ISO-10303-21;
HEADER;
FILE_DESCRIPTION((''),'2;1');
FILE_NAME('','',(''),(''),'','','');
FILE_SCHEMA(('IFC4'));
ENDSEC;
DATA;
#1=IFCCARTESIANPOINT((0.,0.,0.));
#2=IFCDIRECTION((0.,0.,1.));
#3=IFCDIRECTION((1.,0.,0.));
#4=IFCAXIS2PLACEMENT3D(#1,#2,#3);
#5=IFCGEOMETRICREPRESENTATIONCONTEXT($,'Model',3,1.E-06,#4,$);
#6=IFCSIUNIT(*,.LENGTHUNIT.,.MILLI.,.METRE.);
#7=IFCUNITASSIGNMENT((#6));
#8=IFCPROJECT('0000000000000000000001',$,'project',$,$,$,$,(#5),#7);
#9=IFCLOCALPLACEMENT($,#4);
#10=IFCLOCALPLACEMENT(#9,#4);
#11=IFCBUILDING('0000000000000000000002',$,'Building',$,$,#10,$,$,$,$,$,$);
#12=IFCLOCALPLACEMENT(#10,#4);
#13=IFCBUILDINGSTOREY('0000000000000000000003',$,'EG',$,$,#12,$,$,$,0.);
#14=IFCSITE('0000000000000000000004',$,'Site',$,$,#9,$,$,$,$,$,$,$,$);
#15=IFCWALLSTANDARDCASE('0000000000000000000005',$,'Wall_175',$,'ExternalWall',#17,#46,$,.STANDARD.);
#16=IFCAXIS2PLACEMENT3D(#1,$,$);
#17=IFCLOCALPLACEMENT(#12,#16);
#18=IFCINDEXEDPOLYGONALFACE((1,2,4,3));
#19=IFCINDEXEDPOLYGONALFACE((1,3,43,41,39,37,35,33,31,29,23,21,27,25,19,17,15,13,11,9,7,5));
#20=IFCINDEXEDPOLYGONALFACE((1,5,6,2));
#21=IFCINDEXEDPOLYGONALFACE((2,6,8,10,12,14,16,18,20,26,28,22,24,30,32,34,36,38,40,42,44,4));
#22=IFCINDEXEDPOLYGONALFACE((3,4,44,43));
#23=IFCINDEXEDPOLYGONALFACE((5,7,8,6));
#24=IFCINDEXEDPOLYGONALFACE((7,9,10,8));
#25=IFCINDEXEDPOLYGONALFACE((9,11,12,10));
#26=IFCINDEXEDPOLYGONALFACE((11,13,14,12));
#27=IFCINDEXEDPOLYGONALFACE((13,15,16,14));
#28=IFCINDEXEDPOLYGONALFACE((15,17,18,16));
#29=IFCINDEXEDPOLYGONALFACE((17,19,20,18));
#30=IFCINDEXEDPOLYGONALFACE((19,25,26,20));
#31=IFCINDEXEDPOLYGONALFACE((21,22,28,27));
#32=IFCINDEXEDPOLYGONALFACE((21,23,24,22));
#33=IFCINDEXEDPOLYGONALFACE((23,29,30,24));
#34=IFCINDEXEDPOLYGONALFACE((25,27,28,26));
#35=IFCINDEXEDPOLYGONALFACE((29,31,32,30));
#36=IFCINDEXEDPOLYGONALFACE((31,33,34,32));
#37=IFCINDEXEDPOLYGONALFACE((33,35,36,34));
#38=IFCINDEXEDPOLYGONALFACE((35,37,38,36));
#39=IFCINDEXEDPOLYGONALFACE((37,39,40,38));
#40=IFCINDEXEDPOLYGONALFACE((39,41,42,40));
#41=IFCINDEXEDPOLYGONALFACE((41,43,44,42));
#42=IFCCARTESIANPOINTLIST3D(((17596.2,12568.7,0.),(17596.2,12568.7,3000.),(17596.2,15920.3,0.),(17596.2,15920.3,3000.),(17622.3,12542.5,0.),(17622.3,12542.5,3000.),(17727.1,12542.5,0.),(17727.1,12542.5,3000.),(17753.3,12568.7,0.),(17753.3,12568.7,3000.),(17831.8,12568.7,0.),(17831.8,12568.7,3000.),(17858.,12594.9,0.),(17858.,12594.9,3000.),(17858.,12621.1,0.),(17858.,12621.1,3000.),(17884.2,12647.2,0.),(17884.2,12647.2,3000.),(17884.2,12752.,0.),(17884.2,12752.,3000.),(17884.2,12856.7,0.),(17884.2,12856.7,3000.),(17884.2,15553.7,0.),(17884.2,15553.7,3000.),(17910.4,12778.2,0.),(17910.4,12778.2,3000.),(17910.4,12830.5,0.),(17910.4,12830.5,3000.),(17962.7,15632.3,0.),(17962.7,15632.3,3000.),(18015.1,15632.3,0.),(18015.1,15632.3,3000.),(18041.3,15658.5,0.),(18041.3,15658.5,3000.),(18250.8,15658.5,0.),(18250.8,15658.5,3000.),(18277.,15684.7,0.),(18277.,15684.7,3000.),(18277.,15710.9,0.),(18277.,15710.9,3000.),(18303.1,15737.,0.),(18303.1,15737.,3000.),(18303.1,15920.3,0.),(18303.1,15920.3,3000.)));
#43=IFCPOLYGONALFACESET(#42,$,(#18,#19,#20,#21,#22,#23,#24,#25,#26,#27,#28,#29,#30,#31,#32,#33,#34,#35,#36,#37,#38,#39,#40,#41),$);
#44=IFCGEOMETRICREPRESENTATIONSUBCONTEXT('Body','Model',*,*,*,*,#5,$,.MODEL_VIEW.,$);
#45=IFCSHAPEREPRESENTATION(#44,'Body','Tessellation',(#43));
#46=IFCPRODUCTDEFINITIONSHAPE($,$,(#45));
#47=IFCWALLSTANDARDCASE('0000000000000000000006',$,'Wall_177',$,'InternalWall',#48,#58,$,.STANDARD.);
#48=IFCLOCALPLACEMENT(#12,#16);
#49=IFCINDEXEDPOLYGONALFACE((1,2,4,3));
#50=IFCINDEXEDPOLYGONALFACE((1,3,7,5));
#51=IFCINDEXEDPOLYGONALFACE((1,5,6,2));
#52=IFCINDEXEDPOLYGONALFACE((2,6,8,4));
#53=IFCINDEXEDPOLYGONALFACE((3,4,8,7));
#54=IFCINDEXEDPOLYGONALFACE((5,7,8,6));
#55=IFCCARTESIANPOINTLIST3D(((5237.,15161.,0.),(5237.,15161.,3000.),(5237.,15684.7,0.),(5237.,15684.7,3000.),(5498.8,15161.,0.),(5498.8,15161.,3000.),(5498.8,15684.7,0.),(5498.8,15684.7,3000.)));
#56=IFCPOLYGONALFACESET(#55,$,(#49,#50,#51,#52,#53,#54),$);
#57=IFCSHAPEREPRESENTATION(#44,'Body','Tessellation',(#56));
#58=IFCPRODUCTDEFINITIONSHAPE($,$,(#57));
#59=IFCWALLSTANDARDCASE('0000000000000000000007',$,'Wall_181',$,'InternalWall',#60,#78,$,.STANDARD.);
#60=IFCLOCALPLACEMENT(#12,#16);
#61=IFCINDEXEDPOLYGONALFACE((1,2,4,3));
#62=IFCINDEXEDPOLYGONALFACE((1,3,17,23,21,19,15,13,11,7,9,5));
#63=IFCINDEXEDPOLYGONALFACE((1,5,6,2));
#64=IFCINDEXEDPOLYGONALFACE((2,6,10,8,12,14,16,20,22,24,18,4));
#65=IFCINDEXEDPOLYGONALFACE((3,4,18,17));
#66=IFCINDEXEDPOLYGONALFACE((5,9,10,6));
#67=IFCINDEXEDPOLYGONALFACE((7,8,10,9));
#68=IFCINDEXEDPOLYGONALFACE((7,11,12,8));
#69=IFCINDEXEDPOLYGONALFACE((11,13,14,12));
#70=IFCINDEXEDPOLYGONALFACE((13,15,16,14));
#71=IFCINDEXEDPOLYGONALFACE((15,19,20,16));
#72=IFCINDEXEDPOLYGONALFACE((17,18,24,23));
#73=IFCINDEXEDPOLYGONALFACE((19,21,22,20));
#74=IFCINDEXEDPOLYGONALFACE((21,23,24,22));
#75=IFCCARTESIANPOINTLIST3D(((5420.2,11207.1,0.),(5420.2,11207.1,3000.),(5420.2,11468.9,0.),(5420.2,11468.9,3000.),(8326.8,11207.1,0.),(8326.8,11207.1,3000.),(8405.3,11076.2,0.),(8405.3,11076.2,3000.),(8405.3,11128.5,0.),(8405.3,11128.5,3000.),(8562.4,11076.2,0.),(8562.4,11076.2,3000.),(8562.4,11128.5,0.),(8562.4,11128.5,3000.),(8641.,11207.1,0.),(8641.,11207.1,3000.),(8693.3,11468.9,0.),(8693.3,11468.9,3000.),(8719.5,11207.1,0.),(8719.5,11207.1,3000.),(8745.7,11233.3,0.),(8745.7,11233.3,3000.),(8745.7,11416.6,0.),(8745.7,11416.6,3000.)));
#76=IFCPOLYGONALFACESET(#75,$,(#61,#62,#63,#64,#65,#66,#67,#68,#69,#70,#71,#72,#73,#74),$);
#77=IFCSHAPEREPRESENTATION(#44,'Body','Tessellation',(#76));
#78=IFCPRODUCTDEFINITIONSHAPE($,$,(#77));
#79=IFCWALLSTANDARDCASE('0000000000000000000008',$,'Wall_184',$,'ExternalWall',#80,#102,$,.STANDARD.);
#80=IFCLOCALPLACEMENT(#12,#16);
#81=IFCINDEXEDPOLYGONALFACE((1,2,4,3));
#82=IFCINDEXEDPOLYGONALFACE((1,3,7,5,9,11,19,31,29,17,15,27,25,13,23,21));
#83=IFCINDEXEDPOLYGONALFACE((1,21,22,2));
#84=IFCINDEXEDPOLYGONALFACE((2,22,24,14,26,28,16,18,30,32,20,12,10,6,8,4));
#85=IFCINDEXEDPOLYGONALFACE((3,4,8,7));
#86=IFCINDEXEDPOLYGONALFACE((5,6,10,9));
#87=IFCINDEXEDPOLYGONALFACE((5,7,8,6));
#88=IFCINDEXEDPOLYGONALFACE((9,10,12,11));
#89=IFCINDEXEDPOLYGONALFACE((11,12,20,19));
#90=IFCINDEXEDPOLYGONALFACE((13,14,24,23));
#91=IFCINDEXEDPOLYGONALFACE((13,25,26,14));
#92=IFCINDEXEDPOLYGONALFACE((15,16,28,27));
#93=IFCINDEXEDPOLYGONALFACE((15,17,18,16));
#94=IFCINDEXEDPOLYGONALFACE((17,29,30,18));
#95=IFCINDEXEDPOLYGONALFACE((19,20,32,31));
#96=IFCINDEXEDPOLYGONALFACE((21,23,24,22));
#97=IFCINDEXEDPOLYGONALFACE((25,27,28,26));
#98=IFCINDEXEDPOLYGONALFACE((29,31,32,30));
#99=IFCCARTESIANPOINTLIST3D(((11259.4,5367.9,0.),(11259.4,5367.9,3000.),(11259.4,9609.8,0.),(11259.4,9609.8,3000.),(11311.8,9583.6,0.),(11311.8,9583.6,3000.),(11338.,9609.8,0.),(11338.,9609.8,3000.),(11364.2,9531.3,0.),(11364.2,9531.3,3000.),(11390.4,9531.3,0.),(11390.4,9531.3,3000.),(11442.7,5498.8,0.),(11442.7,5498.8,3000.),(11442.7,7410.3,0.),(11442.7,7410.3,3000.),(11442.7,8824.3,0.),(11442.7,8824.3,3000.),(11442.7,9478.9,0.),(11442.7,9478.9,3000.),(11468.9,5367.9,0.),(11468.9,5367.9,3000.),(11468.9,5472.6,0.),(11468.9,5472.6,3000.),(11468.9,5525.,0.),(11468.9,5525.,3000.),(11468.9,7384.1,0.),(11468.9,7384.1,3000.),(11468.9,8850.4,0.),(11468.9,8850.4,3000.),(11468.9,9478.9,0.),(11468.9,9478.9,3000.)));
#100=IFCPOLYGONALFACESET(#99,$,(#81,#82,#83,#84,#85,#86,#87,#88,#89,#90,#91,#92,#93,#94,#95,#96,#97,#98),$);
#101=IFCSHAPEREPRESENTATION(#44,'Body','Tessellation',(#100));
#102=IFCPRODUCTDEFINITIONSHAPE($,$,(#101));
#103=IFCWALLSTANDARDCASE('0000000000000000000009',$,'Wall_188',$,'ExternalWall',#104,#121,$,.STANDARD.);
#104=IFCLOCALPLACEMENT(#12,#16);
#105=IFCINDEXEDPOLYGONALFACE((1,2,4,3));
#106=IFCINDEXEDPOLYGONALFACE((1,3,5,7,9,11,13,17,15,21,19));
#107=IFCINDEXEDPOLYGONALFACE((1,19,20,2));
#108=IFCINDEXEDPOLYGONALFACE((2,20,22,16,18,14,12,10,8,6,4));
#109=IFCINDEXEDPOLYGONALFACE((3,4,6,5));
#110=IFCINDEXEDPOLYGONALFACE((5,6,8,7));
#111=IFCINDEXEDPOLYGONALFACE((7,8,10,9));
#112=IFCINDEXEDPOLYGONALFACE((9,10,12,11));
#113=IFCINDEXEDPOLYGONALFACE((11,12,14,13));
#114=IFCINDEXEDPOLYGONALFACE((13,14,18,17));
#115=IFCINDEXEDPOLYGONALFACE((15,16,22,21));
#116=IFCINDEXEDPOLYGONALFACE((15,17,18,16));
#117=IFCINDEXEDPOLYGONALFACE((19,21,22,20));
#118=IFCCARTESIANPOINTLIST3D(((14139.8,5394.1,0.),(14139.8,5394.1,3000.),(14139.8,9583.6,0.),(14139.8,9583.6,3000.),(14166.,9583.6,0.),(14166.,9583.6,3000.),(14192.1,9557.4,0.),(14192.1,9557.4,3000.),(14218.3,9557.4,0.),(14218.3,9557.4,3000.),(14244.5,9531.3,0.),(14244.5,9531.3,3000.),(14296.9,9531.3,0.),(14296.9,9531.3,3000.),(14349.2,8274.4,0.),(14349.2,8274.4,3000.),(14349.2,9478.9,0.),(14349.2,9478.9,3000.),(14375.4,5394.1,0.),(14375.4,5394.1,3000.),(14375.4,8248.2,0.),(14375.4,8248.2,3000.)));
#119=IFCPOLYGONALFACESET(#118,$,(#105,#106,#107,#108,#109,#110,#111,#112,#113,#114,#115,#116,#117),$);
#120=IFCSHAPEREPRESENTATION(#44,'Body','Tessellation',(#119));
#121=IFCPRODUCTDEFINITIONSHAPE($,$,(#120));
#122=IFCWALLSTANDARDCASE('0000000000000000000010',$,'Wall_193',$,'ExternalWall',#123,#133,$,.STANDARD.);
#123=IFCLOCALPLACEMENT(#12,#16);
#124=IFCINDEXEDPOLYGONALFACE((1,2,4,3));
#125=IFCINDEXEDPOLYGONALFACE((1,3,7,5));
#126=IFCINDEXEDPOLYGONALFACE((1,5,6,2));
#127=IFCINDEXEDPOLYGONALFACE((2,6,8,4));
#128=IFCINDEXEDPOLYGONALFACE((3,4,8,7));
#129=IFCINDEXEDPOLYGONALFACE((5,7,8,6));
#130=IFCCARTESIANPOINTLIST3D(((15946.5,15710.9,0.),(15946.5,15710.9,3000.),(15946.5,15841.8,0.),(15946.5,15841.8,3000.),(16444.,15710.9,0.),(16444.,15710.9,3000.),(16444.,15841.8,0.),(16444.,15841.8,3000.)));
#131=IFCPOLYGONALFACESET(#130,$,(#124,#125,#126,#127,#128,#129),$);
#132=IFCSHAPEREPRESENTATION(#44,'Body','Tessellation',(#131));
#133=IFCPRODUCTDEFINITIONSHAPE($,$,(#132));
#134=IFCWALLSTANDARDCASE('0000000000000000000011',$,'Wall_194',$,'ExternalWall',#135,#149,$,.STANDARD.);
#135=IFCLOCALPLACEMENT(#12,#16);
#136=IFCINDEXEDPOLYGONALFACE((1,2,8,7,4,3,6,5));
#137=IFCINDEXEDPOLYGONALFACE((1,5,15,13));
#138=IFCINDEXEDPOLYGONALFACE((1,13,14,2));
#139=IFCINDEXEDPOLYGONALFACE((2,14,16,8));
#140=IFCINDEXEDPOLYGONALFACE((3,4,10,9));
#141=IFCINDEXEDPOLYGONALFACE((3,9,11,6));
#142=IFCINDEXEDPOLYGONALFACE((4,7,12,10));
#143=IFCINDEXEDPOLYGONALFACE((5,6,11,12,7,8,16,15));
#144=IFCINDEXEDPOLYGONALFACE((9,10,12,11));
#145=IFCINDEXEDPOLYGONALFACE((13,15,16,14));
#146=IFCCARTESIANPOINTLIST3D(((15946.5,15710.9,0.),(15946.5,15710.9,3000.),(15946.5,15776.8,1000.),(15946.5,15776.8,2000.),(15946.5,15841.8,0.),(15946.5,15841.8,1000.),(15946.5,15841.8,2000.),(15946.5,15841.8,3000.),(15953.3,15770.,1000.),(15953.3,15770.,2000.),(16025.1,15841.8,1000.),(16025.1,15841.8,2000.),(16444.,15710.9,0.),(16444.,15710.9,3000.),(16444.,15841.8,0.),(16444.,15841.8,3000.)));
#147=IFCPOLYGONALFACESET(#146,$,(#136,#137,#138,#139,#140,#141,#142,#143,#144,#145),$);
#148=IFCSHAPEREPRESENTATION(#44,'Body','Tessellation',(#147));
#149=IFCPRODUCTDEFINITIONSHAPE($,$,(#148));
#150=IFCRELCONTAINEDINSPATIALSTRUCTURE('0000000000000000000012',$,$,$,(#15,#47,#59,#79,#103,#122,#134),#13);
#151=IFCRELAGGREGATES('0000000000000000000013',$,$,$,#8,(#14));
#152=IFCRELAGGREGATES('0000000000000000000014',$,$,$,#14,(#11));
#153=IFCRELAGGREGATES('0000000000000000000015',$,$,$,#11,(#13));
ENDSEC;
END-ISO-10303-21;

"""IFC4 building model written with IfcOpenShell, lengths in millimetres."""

from ifc_helpers import new_model, si_unit, frame, origin_with_axes, place, context, subcontext, project, spatial, polyline, rectangle, outline, extrude, element, save


model = new_model("IFC4")

# Units and contexts
model_context = context("Model", 3, precision=1e-06, world=origin_with_axes())
body_context = subcontext(model_context, "Body", "Model", "MODEL_VIEW")
ifc_project = project(units=[si_unit("LENGTHUNIT", "METRE", prefix="MILLI")], contexts=[model_context])

# Site, building, storey
site_placement = place(None, origin_with_axes())
site = spatial("IfcSite", under=ifc_project, at=site_placement, Name="Site")
building_placement = place(site_placement, origin_with_axes())
building = spatial("IfcBuilding", under=site, at=building_placement, Name="Building")
storey_placement = place(building_placement, origin_with_axes())
storey = spatial("IfcBuildingStorey", under=building, at=storey_placement, Name="EG", Elevation=0.0)

# Walls
for number, where, z_axis, x_axis, name in (
    (1, (0.0, 0.0, 0.0), (0.0, 0.0, 1.0), (1.0, 0.0, 0.0), "Wall_175"),
):
    element("IfcWallStandardCase", number, at=place(storey_placement, frame(where, z_axis=z_axis, x_axis=x_axis)), inside=storey, Name=name, ObjectType="ExternalWall", PredefinedType="STANDARD", context=body_context, shape_type="SweptSolid", body=[
        extrude(outline(polyline([(17622.3, 12542.5, 0.0), (17596.2, 12568.7, 0.0), (17596.2, 15920.3, 0.0), (18303.1, 15920.3, 0.0), (18303.1, 15737.0, 0.0), (18277.0, 15710.9, 0.0), (18277.0, 15684.7, 0.0), (18250.8, 15658.5, 0.0), (18041.3, 15658.5, 0.0), (18015.1, 15632.3, 0.0), (17962.7, 15632.3, 0.0), (17884.2, 15553.7, 0.0), (17884.2, 12856.7, 0.0), (17910.4, 12830.5, 0.0), (17910.4, 12778.2, 0.0), (17884.2, 12752.0, 0.0), (17884.2, 12647.2, 0.0), (17858.0, 12621.1, 0.0), (17858.0, 12594.9, 0.0), (17831.8, 12568.7, 0.0), (17753.3, 12568.7, 0.0), (17727.1, 12542.5, 0.0), (17622.3, 12542.5, 0.0)])), origin_with_axes(), (0.0, 0.0, 1.0), 3000.0),
    ])
for number, where, z_axis, x_axis, name in (
    (2, (0.0, 0.0, 0.0), (0.0, 0.0, 1.0), (1.0, 0.0, 0.0), "Wall_177"),
):
    element("IfcWallStandardCase", number, at=place(storey_placement, frame(where, z_axis=z_axis, x_axis=x_axis)), inside=storey, Name=name, ObjectType="InternalWall", PredefinedType="STANDARD", context=body_context, shape_type="SweptSolid", body=[
        extrude(outline(polyline([(5237.0, 15161.0, 0.0), (5237.0, 15684.7, 0.0), (5498.8, 15684.7, 0.0), (5498.8, 15161.0, 0.0), (5237.0, 15161.0, 0.0)])), origin_with_axes(), (0.0, 0.0, 1.0), 3000.0),
    ])
for number, where, z_axis, x_axis, name in (
    (3, (0.0, 0.0, 0.0), (0.0, 0.0, 1.0), (1.0, 0.0, 0.0), "Wall_181"),
):
    element("IfcWallStandardCase", number, at=place(storey_placement, frame(where, z_axis=z_axis, x_axis=x_axis)), inside=storey, Name=name, ObjectType="InternalWall", PredefinedType="STANDARD", context=body_context, shape_type="SweptSolid", body=[
        extrude(outline(polyline([(8405.3, 11076.2, 0.0), (8405.3, 11128.5, 0.0), (8326.8, 11207.1, 0.0), (5420.2, 11207.1, 0.0), (5420.2, 11468.9, 0.0), (8693.3, 11468.9, 0.0), (8745.7, 11416.6, 0.0), (8745.7, 11233.3, 0.0), (8719.5, 11207.1, 0.0), (8641.0, 11207.1, 0.0), (8562.4, 11128.5, 0.0), (8562.4, 11076.2, 0.0), (8405.3, 11076.2, 0.0)])), origin_with_axes(), (0.0, 0.0, 1.0), 3000.0),
    ])
for number, where, z_axis, x_axis, name in (
    (4, (0.0, 0.0, 0.0), (0.0, 0.0, 1.0), (1.0, 0.0, 0.0), "Wall_184"),
):
    element("IfcWallStandardCase", number, at=place(storey_placement, frame(where, z_axis=z_axis, x_axis=x_axis)), inside=storey, Name=name, ObjectType="ExternalWall", PredefinedType="STANDARD", context=body_context, shape_type="SweptSolid", body=[
        extrude(outline(polyline([(11259.4, 5367.9, 0.0), (11259.4, 9609.8, 0.0), (11338.0, 9609.8, 0.0), (11311.8, 9583.6, 0.0), (11364.2, 9531.3, 0.0), (11390.4, 9531.3, 0.0), (11442.7, 9478.9, 0.0), (11468.9, 9478.9, 0.0), (11468.9, 8850.4, 0.0), (11442.7, 8824.3, 0.0), (11442.7, 7410.3, 0.0), (11468.9, 7384.1, 0.0), (11468.9, 5525.0, 0.0), (11442.7, 5498.8, 0.0), (11468.9, 5472.6, 0.0), (11468.9, 5367.9, 0.0), (11259.4, 5367.9, 0.0)])), origin_with_axes(), (0.0, 0.0, 1.0), 3000.0),
    ])
for number, where, z_axis, x_axis, name in (
    (5, (0.0, 0.0, 0.0), (0.0, 0.0, 1.0), (1.0, 0.0, 0.0), "Wall_188"),
):
    element("IfcWallStandardCase", number, at=place(storey_placement, frame(where, z_axis=z_axis, x_axis=x_axis)), inside=storey, Name=name, ObjectType="ExternalWall", PredefinedType="STANDARD", context=body_context, shape_type="SweptSolid", body=[
        extrude(outline(polyline([(14139.8, 5394.1, 0.0), (14139.8, 9583.6, 0.0), (14166.0, 9583.6, 0.0), (14192.1, 9557.4, 0.0), (14218.3, 9557.4, 0.0), (14244.5, 9531.3, 0.0), (14296.9, 9531.3, 0.0), (14349.2, 9478.9, 0.0), (14349.2, 8274.4, 0.0), (14375.4, 8248.2, 0.0), (14375.4, 5394.1, 0.0), (14139.8, 5394.1, 0.0)])), origin_with_axes(), (0.0, 0.0, 1.0), 3000.0),
    ])
wall_1_placement = place(storey_placement, origin_with_axes())
element("IfcWallStandardCase", 6, at=wall_1_placement, inside=storey, Name="Wall_193", ObjectType="ExternalWall", PredefinedType="STANDARD", context=body_context, shape_type="SweptSolid", body=[
    extrude(outline(polyline([(15946.5, 15710.9, 0.0), (15946.5, 15841.8, 0.0), (16444.0, 15841.8, 0.0), (16444.0, 15710.9, 0.0), (15946.5, 15710.9, 0.0)])), origin_with_axes(), (0.0, 0.0, 1.0), 3000.0),
])

# Wall, opening
wall_2_placement = place(storey_placement, origin_with_axes())
wall_2 = element("IfcWallStandardCase", 7, at=wall_2_placement, inside=storey, Name="Wall_194", ObjectType="ExternalWall", PredefinedType="STANDARD", context=body_context, shape_type="SweptSolid", body=[
    extrude(outline(polyline([(15946.5, 15710.9, 0.0), (15946.5, 15841.8, 0.0), (16444.0, 15841.8, 0.0), (16444.0, 15710.9, 0.0), (15946.5, 15710.9, 0.0)])), origin_with_axes(), (0.0, 0.0, 1.0), 3000.0),
])
opening_placement = place(wall_2_placement, origin_with_axes())
element("IfcOpeningElement", 8, at=opening_placement, inside=storey, cuts=wall_2, context=body_context, shape_type="SweptSolid", body=[
    extrude(rectangle(XDim=833.2, YDim=115.0), frame((15699.4, 16105.2, 1000.0), z_axis=(0.0, 0.0, 1.0), x_axis=(-0.707107, 0.707107, 0.0)), (0.0, 0.0, 1.0), 1000.0),
])

save(model, "model.ifc")
